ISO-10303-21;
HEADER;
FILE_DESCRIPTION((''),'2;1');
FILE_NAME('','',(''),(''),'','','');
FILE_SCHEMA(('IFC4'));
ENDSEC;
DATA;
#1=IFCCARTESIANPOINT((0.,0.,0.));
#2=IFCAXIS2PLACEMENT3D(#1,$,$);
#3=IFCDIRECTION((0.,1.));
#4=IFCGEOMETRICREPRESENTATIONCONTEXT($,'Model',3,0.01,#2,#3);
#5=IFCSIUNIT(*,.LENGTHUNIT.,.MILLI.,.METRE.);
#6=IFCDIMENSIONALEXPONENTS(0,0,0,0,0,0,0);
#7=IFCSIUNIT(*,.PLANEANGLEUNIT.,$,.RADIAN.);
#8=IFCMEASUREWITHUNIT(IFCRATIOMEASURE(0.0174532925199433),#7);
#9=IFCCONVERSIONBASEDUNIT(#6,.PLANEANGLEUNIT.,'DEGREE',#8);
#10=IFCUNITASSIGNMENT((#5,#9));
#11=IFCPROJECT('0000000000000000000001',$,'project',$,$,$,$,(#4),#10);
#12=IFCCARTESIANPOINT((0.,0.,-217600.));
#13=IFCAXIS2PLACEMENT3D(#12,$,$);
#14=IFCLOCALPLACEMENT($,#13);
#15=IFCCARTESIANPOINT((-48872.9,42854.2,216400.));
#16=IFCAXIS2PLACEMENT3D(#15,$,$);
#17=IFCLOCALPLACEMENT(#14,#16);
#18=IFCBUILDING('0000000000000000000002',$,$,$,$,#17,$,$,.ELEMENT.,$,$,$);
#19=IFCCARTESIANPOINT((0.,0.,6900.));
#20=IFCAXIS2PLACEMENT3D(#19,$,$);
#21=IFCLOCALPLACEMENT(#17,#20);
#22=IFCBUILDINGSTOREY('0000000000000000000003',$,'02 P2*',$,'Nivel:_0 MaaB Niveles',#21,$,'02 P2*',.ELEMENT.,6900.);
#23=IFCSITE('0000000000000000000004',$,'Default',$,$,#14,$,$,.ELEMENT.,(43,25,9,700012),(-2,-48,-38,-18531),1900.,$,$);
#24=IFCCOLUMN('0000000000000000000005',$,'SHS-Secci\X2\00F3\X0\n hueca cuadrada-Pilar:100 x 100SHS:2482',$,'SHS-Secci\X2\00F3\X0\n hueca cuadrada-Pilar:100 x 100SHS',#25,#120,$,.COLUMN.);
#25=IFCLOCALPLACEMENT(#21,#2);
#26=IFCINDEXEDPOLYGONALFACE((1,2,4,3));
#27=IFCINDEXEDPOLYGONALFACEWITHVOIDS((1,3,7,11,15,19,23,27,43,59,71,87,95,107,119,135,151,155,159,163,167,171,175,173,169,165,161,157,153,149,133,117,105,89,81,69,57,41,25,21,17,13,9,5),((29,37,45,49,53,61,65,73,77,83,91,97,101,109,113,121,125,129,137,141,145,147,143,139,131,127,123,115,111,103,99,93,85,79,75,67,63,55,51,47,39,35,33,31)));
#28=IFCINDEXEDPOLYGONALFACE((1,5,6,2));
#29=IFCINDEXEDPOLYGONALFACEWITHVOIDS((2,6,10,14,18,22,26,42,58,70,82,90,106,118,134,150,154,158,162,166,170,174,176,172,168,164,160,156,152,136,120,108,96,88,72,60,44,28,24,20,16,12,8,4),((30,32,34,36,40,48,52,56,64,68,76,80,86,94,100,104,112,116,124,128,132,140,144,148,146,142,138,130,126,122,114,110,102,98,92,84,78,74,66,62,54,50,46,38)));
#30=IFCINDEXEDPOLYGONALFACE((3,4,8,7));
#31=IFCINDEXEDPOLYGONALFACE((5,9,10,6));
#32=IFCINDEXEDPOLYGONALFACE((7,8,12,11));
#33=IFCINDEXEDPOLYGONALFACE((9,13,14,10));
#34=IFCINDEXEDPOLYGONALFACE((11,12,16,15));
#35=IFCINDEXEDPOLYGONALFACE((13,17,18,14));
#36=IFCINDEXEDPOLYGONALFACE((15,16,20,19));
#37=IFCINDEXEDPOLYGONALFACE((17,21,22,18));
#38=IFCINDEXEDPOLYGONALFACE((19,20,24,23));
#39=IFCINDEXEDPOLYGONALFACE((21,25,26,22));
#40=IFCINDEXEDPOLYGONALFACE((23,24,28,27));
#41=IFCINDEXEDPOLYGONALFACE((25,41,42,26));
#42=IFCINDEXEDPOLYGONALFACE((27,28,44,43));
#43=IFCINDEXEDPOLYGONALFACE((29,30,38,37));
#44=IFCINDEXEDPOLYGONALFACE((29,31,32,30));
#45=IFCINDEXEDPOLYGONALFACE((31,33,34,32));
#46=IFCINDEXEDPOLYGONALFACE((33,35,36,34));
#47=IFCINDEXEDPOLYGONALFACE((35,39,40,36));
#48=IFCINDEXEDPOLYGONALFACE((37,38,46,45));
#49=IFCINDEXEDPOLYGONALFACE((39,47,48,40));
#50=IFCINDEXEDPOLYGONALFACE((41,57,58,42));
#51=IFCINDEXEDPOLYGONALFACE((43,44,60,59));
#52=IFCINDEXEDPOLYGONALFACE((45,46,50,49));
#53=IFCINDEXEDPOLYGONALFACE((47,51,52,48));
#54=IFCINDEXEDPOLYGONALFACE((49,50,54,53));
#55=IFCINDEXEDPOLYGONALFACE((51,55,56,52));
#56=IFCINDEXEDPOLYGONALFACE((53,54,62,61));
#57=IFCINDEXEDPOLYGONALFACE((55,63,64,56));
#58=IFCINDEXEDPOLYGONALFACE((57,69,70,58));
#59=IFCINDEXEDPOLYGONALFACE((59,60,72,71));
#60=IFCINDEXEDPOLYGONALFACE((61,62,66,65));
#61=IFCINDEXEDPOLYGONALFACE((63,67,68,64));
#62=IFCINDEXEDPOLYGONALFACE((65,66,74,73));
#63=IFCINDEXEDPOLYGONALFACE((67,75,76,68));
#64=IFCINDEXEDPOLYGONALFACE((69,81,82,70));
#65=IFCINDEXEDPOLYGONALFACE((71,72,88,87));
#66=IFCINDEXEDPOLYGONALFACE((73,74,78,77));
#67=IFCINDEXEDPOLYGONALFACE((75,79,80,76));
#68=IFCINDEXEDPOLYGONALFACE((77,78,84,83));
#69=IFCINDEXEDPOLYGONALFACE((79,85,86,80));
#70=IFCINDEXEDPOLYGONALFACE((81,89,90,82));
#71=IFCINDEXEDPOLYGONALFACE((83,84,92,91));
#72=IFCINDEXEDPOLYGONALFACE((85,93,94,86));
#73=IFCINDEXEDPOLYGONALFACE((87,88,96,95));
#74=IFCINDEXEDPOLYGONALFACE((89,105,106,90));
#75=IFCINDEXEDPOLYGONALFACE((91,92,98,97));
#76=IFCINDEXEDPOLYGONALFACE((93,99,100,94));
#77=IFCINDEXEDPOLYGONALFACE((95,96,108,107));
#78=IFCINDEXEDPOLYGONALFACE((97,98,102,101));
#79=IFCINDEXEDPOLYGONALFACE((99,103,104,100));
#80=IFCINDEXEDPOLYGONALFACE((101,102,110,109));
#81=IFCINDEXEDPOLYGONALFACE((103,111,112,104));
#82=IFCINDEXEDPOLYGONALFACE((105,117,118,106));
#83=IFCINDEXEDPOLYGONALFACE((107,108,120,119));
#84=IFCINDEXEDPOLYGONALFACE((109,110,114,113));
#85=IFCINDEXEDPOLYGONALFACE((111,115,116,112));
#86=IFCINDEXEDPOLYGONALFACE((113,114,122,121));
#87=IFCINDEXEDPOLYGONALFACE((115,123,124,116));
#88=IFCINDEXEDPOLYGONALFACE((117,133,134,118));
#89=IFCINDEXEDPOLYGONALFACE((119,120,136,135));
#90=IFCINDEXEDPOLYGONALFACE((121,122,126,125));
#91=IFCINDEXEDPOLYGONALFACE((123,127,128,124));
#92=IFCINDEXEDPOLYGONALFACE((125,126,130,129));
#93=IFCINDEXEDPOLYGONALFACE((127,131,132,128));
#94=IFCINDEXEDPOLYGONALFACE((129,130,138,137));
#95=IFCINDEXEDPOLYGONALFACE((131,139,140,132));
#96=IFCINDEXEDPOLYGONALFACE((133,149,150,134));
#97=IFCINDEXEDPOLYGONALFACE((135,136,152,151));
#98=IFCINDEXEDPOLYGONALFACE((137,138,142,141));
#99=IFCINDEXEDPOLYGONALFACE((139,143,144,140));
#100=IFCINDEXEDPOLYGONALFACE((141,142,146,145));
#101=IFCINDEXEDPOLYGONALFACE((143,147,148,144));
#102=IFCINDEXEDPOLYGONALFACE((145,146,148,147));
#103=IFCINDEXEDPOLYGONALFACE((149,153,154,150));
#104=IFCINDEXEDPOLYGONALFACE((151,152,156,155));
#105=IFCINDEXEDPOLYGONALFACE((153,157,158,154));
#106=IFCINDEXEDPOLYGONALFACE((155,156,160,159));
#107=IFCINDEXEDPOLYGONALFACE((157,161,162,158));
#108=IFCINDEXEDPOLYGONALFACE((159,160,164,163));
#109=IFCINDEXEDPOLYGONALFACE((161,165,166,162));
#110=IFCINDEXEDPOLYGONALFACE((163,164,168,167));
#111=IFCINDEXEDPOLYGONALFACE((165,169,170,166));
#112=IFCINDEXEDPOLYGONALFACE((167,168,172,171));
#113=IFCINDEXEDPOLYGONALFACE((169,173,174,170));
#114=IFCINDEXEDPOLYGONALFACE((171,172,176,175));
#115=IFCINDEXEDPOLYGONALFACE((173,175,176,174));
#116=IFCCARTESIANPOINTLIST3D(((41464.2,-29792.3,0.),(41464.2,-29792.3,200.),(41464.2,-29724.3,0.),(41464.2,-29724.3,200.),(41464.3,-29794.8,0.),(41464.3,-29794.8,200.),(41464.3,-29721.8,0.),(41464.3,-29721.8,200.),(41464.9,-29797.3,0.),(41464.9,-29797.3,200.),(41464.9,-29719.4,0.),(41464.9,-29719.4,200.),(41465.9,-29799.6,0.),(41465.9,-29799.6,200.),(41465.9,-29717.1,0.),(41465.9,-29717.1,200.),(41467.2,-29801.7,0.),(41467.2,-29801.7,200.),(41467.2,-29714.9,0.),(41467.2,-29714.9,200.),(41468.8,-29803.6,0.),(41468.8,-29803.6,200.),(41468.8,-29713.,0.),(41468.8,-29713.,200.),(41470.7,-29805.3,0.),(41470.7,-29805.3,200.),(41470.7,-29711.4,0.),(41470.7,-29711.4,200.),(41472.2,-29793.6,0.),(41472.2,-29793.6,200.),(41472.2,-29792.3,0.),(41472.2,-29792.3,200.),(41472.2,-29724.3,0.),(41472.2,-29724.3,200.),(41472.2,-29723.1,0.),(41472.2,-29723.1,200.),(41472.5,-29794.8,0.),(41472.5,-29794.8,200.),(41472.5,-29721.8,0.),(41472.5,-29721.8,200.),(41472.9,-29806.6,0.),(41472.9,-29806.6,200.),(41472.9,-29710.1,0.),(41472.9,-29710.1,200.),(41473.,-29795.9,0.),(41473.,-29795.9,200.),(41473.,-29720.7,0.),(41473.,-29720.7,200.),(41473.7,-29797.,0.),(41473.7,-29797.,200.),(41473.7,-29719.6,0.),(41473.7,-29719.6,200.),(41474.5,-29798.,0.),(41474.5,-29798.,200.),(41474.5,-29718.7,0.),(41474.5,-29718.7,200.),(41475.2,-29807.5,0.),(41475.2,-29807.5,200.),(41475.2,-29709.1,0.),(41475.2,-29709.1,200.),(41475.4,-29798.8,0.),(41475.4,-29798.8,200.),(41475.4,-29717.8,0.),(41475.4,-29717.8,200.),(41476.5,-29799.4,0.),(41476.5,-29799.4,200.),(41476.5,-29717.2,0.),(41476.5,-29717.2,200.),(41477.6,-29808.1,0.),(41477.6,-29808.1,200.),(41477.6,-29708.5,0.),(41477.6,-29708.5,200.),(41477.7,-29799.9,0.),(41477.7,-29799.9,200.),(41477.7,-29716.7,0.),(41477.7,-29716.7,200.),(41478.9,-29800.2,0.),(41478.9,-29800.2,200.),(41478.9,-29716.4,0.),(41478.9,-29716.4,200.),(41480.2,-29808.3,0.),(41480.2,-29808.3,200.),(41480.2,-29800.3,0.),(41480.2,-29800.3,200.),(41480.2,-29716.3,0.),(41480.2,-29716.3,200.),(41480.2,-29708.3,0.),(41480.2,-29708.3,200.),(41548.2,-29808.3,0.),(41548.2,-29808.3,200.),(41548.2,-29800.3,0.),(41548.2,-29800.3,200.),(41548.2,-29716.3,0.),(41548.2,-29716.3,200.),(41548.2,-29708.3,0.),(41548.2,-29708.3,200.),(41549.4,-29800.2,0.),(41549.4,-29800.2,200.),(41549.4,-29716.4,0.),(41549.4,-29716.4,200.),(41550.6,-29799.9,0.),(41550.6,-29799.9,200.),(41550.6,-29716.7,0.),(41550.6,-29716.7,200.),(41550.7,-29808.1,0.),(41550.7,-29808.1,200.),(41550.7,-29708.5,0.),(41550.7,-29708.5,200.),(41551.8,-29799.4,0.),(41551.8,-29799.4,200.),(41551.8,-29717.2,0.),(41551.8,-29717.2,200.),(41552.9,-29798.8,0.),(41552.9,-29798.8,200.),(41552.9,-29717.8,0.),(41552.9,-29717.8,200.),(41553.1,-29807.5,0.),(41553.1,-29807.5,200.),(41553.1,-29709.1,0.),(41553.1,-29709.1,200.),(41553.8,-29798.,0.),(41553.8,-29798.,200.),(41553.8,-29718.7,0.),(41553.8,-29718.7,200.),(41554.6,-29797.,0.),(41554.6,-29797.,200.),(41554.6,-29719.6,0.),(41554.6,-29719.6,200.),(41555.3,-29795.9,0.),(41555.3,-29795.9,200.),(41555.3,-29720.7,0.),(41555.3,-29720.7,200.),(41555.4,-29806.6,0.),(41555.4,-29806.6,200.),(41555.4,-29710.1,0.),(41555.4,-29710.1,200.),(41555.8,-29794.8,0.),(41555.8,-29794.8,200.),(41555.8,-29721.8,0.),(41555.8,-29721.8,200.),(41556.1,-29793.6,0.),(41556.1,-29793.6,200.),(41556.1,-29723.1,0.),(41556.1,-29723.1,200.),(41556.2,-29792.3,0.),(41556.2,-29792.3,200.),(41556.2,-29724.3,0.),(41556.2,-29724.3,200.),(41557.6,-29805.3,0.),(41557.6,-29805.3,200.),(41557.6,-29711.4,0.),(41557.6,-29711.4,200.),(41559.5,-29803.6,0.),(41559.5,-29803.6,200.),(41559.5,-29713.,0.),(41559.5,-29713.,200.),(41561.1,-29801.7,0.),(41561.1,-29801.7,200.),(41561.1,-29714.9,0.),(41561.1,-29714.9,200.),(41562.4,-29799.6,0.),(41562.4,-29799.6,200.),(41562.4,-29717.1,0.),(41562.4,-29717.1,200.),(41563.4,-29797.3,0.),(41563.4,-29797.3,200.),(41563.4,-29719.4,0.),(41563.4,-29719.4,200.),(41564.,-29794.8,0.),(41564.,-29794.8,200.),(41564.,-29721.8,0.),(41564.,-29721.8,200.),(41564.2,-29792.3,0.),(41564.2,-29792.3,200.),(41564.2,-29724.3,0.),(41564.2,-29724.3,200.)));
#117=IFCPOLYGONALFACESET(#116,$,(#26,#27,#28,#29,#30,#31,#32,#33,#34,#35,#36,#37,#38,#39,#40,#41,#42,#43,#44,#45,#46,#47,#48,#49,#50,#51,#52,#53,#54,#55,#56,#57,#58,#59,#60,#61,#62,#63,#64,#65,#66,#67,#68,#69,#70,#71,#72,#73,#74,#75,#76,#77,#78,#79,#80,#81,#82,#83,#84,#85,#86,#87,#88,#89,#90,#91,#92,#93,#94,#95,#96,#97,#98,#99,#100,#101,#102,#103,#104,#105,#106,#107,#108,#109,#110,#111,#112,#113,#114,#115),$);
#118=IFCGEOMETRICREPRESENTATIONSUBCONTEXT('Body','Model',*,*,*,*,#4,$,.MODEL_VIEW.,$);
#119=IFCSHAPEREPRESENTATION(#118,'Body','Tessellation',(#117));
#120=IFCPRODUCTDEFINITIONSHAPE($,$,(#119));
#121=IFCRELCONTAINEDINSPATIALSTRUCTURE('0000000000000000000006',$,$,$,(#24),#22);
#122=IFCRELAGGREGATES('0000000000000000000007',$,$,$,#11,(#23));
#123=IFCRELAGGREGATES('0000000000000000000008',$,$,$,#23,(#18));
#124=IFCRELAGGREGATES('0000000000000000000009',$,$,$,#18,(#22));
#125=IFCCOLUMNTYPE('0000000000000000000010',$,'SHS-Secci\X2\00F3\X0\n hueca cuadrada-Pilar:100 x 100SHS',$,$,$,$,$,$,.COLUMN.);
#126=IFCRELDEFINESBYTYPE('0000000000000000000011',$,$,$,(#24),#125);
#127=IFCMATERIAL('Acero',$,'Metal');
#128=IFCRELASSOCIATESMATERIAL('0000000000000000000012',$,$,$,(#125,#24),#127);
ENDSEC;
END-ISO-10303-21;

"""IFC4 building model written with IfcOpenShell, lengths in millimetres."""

from ifc_helpers import new_model, entity, si_unit, converted_unit, direction, frame, origin, place, context, subcontext, project, spatial, indexed_curve, outline, extrude, source, transform, mapped, material, type_object, type_shapes, element, save


model = new_model("IFC4")

# Units and contexts
model_context = context("Model", 3, precision=0.01, world=origin(), true_north=direction((0.0, 1.0)))
body_context = subcontext(model_context, "Body", "Model", "MODEL_VIEW")
ifc_project = project(units=[si_unit("LENGTHUNIT", "METRE", prefix="MILLI"), converted_unit("PLANEANGLEUNIT", "DEGREE", entity("IfcRatioMeasure", 0.0174532925199433), si_unit("PLANEANGLEUNIT", "RADIAN"), dimensions=[0, 0, 0, 0, 0, 0, 0])], contexts=[model_context])

# Site, building, storey
site_placement = place(None, frame((0.0, 0.0, -217600.0)))
site = spatial("IfcSite", under=ifc_project, at=site_placement, Name="Default", CompositionType="ELEMENT", RefLatitude=(43, 25, 9, 700012), RefLongitude=(-2, -48, -38, -18531), RefElevation=1900.0)
building_placement = place(site_placement, frame((-48872.9, 42854.2, 216400.0)))
building = spatial("IfcBuilding", under=site, at=building_placement, CompositionType="ELEMENT")
storey_placement = place(building_placement, frame((0.0, 0.0, 6900.0)))
storey = spatial("IfcBuildingStorey", under=building, at=storey_placement, Name="02 P2*", ObjectType="Nivel:_0 MaaB Niveles", LongName="02 P2*", CompositionType="ELEMENT", Elevation=6900.0)

# Column
ifc_material_1 = material(Name="Acero", Category="Metal")
column_type_1 = type_object("IfcColumnType", Name="SHS-Sección hueca cuadrada-Pilar:100 x 100SHS", PredefinedType="COLUMN", material=ifc_material_1)
shared_shape_1 = source(origin(), body_context, "Body", "SweptSolid", [
    extrude(outline(indexed_curve([(-34.0, -50.0), (34.0, -50.0), (36.5, -49.8), (38.9, -49.2), (41.3, -48.3), (43.4, -46.9), (45.3, -45.3), (46.9, -43.4), (48.3, -41.3), (49.2, -38.9), (49.8, -36.5), (50.0, -34.0), (50.0, 34.0), (49.8, 36.5), (49.2, 38.9), (48.3, 41.3), (46.9, 43.4), (45.3, 45.3), (43.4, 46.9), (41.3, 48.3), (38.9, 49.2), (36.5, 49.8), (34.0, 50.0), (-34.0, 50.0), (-36.5, 49.8), (-38.9, 49.2), (-41.3, 48.3), (-43.4, 46.9), (-45.3, 45.3), (-46.9, 43.4), (-48.3, 41.3), (-49.2, 38.9), (-49.8, 36.5), (-50.0, 34.0), (-50.0, -34.0), (-49.8, -36.5), (-49.2, -38.9), (-48.3, -41.3), (-46.9, -43.4), (-45.3, -45.3), (-43.4, -46.9), (-41.3, -48.3), (-38.9, -49.2), (-36.5, -49.8), (-34.0, -50.0)], self_intersect=False), holes=[indexed_curve([(-42.0, 34.0), (-41.9, 35.3), (-41.6, 36.5), (-41.1, 37.6), (-40.5, 38.7), (-39.7, 39.7), (-38.7, 40.5), (-37.6, 41.1), (-36.5, 41.6), (-35.3, 41.9), (-34.0, 42.0), (34.0, 42.0), (35.3, 41.9), (36.5, 41.6), (37.6, 41.1), (38.7, 40.5), (39.7, 39.7), (40.5, 38.7), (41.1, 37.6), (41.6, 36.5), (41.9, 35.3), (42.0, 34.0), (42.0, -34.0), (41.9, -35.3), (41.6, -36.5), (41.1, -37.6), (40.5, -38.7), (39.7, -39.7), (38.7, -40.5), (37.6, -41.1), (36.5, -41.6), (35.3, -41.9), (34.0, -42.0), (-34.0, -42.0), (-35.3, -41.9), (-36.5, -41.6), (-37.6, -41.1), (-38.7, -40.5), (-39.7, -39.7), (-40.5, -38.7), (-41.1, -37.6), (-41.6, -36.5), (-41.9, -35.3), (-42.0, -34.0), (-42.0, 34.0)], self_intersect=False)]), frame((0.0, 0.0, 6900.0), z_axis=(0.0, 0.0, 1.0), x_axis=(0.0, 1.0, 0.0)), (0.0, 0.0, 1.0), 200.0),
])
type_shapes(column_type_1, [shared_shape_1])
column_1_placement = place(storey_placement, frame((41514.2, -29758.3, -6900.0), z_axis=(0.0, 0.0, 1.0), x_axis=(0.0, -1.0, 0.0)))
element("IfcColumn", 1, at=column_1_placement, inside=storey, type_object=column_type_1, material=ifc_material_1, Name="SHS-Sección hueca cuadrada-Pilar:100 x 100SHS:2482", ObjectType="SHS-Sección hueca cuadrada-Pilar:100 x 100SHS", PredefinedType="COLUMN", context=body_context, shape_type="MappedRepresentation", body=[
    mapped(shared_shape_1, transform((0.0, 0.0, 0.0), scale=1.0)),
])

save(model, "model.ifc")
